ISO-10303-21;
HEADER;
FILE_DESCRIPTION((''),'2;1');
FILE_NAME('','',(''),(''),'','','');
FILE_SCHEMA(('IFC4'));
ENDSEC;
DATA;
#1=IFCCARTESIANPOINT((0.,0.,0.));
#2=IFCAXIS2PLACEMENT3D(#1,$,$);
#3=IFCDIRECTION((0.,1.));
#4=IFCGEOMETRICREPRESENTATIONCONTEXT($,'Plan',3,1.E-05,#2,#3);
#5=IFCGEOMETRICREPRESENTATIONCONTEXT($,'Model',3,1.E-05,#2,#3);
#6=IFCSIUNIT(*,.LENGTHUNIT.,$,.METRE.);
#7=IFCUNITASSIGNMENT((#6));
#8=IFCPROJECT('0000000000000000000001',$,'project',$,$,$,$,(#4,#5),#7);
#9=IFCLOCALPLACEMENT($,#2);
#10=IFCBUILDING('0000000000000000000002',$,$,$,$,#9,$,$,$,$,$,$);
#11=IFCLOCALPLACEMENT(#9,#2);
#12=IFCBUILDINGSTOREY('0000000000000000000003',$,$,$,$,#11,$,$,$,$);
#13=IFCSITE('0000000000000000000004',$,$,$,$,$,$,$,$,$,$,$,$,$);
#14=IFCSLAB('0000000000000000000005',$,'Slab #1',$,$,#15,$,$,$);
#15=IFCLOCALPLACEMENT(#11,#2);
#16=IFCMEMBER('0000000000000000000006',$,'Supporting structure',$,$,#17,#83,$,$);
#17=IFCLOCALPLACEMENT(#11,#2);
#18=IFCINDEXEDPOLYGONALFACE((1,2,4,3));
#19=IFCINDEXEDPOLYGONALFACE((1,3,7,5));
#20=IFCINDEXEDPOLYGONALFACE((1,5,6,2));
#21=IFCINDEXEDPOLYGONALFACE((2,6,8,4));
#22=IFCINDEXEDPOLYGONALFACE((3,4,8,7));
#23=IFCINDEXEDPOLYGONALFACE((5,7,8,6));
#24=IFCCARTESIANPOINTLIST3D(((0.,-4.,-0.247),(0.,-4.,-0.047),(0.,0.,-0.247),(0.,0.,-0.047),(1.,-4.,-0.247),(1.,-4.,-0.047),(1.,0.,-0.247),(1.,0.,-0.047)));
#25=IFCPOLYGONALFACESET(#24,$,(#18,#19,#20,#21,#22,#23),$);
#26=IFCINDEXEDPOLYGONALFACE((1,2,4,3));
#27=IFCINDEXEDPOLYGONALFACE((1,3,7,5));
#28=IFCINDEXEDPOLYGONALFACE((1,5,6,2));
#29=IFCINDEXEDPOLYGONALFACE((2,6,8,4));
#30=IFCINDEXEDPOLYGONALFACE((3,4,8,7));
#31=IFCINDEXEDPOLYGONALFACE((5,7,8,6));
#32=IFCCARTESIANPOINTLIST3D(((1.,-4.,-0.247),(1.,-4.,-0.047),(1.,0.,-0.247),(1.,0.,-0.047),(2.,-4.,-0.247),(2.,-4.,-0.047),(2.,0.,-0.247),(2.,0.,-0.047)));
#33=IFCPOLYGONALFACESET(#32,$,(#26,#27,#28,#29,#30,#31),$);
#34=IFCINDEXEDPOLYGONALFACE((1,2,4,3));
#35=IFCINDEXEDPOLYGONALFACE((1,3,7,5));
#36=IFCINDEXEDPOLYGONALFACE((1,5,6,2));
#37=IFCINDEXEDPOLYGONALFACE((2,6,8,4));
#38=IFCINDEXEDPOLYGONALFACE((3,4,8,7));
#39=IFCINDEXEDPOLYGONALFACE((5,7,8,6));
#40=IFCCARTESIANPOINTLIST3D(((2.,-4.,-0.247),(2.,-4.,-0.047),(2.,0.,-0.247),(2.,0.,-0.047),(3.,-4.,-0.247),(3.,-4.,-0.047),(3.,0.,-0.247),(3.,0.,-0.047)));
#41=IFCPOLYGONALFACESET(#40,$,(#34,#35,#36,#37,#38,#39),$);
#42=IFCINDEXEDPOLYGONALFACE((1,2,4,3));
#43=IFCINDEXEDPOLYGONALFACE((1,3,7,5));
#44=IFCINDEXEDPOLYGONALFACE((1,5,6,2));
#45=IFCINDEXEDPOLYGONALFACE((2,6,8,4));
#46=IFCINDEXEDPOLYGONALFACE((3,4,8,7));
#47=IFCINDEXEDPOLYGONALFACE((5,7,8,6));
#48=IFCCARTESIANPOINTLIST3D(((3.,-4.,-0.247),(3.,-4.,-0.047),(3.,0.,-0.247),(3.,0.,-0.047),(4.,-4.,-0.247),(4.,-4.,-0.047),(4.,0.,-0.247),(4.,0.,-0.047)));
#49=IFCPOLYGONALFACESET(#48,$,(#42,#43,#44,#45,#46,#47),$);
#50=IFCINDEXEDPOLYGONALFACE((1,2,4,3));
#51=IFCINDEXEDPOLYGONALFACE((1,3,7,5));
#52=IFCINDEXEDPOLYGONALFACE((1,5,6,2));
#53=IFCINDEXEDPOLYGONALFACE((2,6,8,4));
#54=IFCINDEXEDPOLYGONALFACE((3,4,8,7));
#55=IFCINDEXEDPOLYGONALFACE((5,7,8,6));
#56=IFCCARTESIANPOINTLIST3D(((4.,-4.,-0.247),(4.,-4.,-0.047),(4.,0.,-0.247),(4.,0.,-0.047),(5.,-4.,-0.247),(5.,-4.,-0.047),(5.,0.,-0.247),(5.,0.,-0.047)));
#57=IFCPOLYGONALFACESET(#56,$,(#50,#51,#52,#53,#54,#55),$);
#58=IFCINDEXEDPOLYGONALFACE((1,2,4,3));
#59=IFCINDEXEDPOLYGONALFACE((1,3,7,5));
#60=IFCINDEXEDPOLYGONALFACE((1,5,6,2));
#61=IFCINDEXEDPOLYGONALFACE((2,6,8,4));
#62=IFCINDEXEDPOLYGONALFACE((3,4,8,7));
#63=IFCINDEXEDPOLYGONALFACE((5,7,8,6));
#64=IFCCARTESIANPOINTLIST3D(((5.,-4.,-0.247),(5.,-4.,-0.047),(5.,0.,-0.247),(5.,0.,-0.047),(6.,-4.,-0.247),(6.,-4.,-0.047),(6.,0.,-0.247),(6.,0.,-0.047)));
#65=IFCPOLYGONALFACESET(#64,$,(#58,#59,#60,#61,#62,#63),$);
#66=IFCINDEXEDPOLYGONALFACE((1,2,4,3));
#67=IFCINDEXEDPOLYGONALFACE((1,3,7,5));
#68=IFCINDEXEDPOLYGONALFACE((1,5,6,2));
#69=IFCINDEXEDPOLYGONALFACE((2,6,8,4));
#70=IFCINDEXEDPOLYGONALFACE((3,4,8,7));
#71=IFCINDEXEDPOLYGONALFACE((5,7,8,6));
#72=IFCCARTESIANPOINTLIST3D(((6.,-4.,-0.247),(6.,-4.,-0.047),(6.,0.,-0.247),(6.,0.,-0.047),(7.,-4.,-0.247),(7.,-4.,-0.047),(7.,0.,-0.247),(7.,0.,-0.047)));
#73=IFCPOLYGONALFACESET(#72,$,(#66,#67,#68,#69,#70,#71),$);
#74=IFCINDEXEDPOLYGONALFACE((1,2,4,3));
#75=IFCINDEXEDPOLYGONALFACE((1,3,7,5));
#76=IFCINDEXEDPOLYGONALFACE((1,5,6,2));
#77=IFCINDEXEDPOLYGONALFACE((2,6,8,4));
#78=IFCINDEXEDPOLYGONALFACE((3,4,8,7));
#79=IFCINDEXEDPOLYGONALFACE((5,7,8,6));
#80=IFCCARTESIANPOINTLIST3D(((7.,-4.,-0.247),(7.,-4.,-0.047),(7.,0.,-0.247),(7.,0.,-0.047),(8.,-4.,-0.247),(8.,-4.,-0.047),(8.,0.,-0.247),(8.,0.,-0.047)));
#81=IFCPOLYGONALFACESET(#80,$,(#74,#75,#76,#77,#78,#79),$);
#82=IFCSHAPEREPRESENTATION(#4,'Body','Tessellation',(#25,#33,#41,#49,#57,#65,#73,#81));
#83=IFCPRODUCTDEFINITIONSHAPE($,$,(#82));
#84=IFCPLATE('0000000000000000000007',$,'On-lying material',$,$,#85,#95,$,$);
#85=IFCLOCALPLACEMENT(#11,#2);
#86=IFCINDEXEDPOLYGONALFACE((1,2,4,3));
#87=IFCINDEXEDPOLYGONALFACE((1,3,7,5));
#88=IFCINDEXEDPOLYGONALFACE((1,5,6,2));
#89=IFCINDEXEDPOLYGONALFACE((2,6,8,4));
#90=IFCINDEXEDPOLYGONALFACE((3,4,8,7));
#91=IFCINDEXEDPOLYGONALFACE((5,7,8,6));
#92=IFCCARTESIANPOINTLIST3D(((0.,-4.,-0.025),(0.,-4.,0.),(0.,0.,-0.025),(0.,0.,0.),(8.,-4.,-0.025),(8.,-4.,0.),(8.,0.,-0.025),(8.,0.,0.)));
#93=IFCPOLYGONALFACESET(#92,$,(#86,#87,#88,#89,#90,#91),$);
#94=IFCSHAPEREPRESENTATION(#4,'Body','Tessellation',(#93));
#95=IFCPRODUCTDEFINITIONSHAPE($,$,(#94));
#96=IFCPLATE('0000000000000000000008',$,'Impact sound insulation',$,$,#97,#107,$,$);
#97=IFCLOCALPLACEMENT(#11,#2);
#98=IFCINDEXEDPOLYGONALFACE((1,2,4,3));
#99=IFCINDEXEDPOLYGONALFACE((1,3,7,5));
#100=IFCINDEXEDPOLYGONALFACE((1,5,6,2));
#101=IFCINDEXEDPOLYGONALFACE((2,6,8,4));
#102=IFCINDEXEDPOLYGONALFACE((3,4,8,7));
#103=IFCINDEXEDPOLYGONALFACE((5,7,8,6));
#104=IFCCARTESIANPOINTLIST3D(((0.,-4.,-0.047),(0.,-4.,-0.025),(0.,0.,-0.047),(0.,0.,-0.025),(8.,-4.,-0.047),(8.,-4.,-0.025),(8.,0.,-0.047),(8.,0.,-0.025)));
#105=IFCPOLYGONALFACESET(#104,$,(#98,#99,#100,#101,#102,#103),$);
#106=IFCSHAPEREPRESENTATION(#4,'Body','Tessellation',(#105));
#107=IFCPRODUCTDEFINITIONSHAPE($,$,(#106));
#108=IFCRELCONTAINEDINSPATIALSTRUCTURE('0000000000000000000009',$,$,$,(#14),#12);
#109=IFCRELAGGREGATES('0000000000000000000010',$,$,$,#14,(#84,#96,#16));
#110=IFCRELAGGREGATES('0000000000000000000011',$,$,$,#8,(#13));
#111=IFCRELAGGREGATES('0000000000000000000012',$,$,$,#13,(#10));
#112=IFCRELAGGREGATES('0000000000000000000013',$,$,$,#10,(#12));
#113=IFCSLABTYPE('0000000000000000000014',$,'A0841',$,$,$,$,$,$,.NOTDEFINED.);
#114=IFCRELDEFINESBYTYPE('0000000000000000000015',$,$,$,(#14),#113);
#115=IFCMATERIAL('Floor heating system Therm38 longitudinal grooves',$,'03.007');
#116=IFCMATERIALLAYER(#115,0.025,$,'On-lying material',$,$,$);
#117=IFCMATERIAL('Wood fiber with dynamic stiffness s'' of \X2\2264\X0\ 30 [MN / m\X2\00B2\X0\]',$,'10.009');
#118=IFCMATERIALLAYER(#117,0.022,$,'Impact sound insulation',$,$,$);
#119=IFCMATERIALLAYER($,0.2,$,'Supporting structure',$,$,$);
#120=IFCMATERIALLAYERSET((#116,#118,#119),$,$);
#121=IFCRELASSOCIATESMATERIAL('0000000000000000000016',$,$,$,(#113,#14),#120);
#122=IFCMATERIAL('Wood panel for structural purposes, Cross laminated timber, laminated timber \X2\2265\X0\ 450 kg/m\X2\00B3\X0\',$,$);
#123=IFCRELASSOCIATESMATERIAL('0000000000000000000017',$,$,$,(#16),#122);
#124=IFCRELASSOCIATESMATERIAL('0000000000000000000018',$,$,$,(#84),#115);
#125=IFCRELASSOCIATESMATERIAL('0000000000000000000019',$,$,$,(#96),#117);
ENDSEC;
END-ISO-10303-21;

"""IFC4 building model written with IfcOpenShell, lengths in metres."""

from ifc_helpers import new_model, si_unit, direction, frame, frame_2d, origin, origin_with_axes, place, context, project, spatial, rectangle, extrude, material, layer, layer_set, type_object, element, aggregate, save


model = new_model("IFC4")

# Units and contexts
plan_context = context("Plan", 3, precision=1e-05, world=origin(), true_north=direction((0.0, 1.0)))
model_context = context("Model", 3, precision=1e-05, world=origin(), true_north=direction((0.0, 1.0)))
ifc_project = project(units=[si_unit("LENGTHUNIT", "METRE")], contexts=[plan_context, model_context])

# Site, building, storey
site = spatial("IfcSite", under=ifc_project)
building_placement = place(None, origin())
building = spatial("IfcBuilding", under=site, at=building_placement)
storey_placement = place(building_placement, origin())
storey = spatial("IfcBuildingStorey", under=building, at=storey_placement)

# Slab, member, plates
ifc_material_1 = material(Name="Floor heating system Therm38 longitudinal grooves", Category="03.007")
ifc_layer_1 = layer(ifc_material_1, 0.025, Name="On-lying material")
ifc_material_2 = material(Name="Wood fiber with dynamic stiffness s' of ≤ 30 [MN / m²]", Category="10.009")
ifc_layer_2 = layer(ifc_material_2, 0.022, Name="Impact sound insulation")
ifc_layer_3 = layer(None, 0.2, Name="Supporting structure")
ifc_layer_set = layer_set([ifc_layer_1, ifc_layer_2, ifc_layer_3])
slab_type = type_object("IfcSlabType", Name="A0841", PredefinedType="NOTDEFINED", material=ifc_layer_set)
slab_placement = place(None, frame((0.0, 0.0, 0.0), z_axis=(0.0, 0.0, -1.0), x_axis=(1.0, 0.0, 0.0)))
slab = element("IfcSlab", 1, at=slab_placement, inside=storey, type_object=slab_type, material=ifc_layer_set, Name="Slab #1")
ifc_material_3 = material(Name="Wood panel for structural purposes, Cross laminated timber, laminated timber ≥ 450 kg/m³")
member_placement = place(slab_placement, origin())
member = element("IfcMember", 2, at=member_placement, material=ifc_material_3, Name="Supporting structure", context=plan_context, shape_type="SweptSolid", body=[
    extrude(rectangle(XDim=1.0, YDim=0.2, at=frame_2d((0.5, 0.1), x_axis=(1.0, 0.0))), frame((0.0, 4.0, 0.047), z_axis=(0.0, -1.0, 0.0), x_axis=(1.0, 0.0, 0.0)), (0.0, 0.0, 1.0), 4.0),
    extrude(rectangle(XDim=1.0, YDim=0.2, at=frame_2d((0.5, 0.1), x_axis=(1.0, 0.0))), frame((1.0, 4.0, 0.047), z_axis=(0.0, -1.0, 0.0), x_axis=(1.0, 0.0, 0.0)), (0.0, 0.0, 1.0), 4.0),
    extrude(rectangle(XDim=1.0, YDim=0.2, at=frame_2d((0.5, 0.1), x_axis=(1.0, 0.0))), frame((2.0, 4.0, 0.047), z_axis=(0.0, -1.0, 0.0), x_axis=(1.0, 0.0, 0.0)), (0.0, 0.0, 1.0), 4.0),
    extrude(rectangle(XDim=1.0, YDim=0.2, at=frame_2d((0.5, 0.1), x_axis=(1.0, 0.0))), frame((3.0, 4.0, 0.047), z_axis=(0.0, -1.0, 0.0), x_axis=(1.0, 0.0, 0.0)), (0.0, 0.0, 1.0), 4.0),
    extrude(rectangle(XDim=1.0, YDim=0.2, at=frame_2d((0.5, 0.1), x_axis=(1.0, 0.0))), frame((4.0, 4.0, 0.047), z_axis=(0.0, -1.0, 0.0), x_axis=(1.0, 0.0, 0.0)), (0.0, 0.0, 1.0), 4.0),
    extrude(rectangle(XDim=1.0, YDim=0.2, at=frame_2d((0.5, 0.1), x_axis=(1.0, 0.0))), frame((5.0, 4.0, 0.047), z_axis=(0.0, -1.0, 0.0), x_axis=(1.0, 0.0, 0.0)), (0.0, 0.0, 1.0), 4.0),
    extrude(rectangle(XDim=1.0, YDim=0.2, at=frame_2d((0.5, 0.1), x_axis=(1.0, 0.0))), frame((6.0, 4.0, 0.047), z_axis=(0.0, -1.0, 0.0), x_axis=(1.0, 0.0, 0.0)), (0.0, 0.0, 1.0), 4.0),
    extrude(rectangle(XDim=1.0, YDim=0.2, at=frame_2d((0.5, 0.1), x_axis=(1.0, 0.0))), frame((7.0, 4.0, 0.047), z_axis=(0.0, -1.0, 0.0), x_axis=(1.0, 0.0, 0.0)), (0.0, 0.0, 1.0), 4.0),
])
plate_1_placement = place(slab_placement, origin())
plate_1 = element("IfcPlate", 3, at=plate_1_placement, material=ifc_material_1, Name="On-lying material", context=plan_context, shape_type="SweptSolid", body=[
    extrude(rectangle(XDim=8.0, YDim=4.0, at=frame_2d((4.0, 2.0), x_axis=(1.0, 0.0))), origin_with_axes(), (0.0, 0.0, 1.0), 0.025),
])
plate_2_placement = place(slab_placement, origin())
plate_2 = element("IfcPlate", 4, at=plate_2_placement, material=ifc_material_2, Name="Impact sound insulation", context=plan_context, shape_type="SweptSolid", body=[
    extrude(rectangle(XDim=8.0, YDim=4.0, at=frame_2d((4.0, 2.0), x_axis=(1.0, 0.0))), frame((0.0, 0.0, 0.025), z_axis=(0.0, 0.0, 1.0), x_axis=(1.0, 0.0, 0.0)), (0.0, 0.0, 1.0), 0.022),
])
aggregate(slab, [plate_1, plate_2, member])

save(model, "model.ifc")
